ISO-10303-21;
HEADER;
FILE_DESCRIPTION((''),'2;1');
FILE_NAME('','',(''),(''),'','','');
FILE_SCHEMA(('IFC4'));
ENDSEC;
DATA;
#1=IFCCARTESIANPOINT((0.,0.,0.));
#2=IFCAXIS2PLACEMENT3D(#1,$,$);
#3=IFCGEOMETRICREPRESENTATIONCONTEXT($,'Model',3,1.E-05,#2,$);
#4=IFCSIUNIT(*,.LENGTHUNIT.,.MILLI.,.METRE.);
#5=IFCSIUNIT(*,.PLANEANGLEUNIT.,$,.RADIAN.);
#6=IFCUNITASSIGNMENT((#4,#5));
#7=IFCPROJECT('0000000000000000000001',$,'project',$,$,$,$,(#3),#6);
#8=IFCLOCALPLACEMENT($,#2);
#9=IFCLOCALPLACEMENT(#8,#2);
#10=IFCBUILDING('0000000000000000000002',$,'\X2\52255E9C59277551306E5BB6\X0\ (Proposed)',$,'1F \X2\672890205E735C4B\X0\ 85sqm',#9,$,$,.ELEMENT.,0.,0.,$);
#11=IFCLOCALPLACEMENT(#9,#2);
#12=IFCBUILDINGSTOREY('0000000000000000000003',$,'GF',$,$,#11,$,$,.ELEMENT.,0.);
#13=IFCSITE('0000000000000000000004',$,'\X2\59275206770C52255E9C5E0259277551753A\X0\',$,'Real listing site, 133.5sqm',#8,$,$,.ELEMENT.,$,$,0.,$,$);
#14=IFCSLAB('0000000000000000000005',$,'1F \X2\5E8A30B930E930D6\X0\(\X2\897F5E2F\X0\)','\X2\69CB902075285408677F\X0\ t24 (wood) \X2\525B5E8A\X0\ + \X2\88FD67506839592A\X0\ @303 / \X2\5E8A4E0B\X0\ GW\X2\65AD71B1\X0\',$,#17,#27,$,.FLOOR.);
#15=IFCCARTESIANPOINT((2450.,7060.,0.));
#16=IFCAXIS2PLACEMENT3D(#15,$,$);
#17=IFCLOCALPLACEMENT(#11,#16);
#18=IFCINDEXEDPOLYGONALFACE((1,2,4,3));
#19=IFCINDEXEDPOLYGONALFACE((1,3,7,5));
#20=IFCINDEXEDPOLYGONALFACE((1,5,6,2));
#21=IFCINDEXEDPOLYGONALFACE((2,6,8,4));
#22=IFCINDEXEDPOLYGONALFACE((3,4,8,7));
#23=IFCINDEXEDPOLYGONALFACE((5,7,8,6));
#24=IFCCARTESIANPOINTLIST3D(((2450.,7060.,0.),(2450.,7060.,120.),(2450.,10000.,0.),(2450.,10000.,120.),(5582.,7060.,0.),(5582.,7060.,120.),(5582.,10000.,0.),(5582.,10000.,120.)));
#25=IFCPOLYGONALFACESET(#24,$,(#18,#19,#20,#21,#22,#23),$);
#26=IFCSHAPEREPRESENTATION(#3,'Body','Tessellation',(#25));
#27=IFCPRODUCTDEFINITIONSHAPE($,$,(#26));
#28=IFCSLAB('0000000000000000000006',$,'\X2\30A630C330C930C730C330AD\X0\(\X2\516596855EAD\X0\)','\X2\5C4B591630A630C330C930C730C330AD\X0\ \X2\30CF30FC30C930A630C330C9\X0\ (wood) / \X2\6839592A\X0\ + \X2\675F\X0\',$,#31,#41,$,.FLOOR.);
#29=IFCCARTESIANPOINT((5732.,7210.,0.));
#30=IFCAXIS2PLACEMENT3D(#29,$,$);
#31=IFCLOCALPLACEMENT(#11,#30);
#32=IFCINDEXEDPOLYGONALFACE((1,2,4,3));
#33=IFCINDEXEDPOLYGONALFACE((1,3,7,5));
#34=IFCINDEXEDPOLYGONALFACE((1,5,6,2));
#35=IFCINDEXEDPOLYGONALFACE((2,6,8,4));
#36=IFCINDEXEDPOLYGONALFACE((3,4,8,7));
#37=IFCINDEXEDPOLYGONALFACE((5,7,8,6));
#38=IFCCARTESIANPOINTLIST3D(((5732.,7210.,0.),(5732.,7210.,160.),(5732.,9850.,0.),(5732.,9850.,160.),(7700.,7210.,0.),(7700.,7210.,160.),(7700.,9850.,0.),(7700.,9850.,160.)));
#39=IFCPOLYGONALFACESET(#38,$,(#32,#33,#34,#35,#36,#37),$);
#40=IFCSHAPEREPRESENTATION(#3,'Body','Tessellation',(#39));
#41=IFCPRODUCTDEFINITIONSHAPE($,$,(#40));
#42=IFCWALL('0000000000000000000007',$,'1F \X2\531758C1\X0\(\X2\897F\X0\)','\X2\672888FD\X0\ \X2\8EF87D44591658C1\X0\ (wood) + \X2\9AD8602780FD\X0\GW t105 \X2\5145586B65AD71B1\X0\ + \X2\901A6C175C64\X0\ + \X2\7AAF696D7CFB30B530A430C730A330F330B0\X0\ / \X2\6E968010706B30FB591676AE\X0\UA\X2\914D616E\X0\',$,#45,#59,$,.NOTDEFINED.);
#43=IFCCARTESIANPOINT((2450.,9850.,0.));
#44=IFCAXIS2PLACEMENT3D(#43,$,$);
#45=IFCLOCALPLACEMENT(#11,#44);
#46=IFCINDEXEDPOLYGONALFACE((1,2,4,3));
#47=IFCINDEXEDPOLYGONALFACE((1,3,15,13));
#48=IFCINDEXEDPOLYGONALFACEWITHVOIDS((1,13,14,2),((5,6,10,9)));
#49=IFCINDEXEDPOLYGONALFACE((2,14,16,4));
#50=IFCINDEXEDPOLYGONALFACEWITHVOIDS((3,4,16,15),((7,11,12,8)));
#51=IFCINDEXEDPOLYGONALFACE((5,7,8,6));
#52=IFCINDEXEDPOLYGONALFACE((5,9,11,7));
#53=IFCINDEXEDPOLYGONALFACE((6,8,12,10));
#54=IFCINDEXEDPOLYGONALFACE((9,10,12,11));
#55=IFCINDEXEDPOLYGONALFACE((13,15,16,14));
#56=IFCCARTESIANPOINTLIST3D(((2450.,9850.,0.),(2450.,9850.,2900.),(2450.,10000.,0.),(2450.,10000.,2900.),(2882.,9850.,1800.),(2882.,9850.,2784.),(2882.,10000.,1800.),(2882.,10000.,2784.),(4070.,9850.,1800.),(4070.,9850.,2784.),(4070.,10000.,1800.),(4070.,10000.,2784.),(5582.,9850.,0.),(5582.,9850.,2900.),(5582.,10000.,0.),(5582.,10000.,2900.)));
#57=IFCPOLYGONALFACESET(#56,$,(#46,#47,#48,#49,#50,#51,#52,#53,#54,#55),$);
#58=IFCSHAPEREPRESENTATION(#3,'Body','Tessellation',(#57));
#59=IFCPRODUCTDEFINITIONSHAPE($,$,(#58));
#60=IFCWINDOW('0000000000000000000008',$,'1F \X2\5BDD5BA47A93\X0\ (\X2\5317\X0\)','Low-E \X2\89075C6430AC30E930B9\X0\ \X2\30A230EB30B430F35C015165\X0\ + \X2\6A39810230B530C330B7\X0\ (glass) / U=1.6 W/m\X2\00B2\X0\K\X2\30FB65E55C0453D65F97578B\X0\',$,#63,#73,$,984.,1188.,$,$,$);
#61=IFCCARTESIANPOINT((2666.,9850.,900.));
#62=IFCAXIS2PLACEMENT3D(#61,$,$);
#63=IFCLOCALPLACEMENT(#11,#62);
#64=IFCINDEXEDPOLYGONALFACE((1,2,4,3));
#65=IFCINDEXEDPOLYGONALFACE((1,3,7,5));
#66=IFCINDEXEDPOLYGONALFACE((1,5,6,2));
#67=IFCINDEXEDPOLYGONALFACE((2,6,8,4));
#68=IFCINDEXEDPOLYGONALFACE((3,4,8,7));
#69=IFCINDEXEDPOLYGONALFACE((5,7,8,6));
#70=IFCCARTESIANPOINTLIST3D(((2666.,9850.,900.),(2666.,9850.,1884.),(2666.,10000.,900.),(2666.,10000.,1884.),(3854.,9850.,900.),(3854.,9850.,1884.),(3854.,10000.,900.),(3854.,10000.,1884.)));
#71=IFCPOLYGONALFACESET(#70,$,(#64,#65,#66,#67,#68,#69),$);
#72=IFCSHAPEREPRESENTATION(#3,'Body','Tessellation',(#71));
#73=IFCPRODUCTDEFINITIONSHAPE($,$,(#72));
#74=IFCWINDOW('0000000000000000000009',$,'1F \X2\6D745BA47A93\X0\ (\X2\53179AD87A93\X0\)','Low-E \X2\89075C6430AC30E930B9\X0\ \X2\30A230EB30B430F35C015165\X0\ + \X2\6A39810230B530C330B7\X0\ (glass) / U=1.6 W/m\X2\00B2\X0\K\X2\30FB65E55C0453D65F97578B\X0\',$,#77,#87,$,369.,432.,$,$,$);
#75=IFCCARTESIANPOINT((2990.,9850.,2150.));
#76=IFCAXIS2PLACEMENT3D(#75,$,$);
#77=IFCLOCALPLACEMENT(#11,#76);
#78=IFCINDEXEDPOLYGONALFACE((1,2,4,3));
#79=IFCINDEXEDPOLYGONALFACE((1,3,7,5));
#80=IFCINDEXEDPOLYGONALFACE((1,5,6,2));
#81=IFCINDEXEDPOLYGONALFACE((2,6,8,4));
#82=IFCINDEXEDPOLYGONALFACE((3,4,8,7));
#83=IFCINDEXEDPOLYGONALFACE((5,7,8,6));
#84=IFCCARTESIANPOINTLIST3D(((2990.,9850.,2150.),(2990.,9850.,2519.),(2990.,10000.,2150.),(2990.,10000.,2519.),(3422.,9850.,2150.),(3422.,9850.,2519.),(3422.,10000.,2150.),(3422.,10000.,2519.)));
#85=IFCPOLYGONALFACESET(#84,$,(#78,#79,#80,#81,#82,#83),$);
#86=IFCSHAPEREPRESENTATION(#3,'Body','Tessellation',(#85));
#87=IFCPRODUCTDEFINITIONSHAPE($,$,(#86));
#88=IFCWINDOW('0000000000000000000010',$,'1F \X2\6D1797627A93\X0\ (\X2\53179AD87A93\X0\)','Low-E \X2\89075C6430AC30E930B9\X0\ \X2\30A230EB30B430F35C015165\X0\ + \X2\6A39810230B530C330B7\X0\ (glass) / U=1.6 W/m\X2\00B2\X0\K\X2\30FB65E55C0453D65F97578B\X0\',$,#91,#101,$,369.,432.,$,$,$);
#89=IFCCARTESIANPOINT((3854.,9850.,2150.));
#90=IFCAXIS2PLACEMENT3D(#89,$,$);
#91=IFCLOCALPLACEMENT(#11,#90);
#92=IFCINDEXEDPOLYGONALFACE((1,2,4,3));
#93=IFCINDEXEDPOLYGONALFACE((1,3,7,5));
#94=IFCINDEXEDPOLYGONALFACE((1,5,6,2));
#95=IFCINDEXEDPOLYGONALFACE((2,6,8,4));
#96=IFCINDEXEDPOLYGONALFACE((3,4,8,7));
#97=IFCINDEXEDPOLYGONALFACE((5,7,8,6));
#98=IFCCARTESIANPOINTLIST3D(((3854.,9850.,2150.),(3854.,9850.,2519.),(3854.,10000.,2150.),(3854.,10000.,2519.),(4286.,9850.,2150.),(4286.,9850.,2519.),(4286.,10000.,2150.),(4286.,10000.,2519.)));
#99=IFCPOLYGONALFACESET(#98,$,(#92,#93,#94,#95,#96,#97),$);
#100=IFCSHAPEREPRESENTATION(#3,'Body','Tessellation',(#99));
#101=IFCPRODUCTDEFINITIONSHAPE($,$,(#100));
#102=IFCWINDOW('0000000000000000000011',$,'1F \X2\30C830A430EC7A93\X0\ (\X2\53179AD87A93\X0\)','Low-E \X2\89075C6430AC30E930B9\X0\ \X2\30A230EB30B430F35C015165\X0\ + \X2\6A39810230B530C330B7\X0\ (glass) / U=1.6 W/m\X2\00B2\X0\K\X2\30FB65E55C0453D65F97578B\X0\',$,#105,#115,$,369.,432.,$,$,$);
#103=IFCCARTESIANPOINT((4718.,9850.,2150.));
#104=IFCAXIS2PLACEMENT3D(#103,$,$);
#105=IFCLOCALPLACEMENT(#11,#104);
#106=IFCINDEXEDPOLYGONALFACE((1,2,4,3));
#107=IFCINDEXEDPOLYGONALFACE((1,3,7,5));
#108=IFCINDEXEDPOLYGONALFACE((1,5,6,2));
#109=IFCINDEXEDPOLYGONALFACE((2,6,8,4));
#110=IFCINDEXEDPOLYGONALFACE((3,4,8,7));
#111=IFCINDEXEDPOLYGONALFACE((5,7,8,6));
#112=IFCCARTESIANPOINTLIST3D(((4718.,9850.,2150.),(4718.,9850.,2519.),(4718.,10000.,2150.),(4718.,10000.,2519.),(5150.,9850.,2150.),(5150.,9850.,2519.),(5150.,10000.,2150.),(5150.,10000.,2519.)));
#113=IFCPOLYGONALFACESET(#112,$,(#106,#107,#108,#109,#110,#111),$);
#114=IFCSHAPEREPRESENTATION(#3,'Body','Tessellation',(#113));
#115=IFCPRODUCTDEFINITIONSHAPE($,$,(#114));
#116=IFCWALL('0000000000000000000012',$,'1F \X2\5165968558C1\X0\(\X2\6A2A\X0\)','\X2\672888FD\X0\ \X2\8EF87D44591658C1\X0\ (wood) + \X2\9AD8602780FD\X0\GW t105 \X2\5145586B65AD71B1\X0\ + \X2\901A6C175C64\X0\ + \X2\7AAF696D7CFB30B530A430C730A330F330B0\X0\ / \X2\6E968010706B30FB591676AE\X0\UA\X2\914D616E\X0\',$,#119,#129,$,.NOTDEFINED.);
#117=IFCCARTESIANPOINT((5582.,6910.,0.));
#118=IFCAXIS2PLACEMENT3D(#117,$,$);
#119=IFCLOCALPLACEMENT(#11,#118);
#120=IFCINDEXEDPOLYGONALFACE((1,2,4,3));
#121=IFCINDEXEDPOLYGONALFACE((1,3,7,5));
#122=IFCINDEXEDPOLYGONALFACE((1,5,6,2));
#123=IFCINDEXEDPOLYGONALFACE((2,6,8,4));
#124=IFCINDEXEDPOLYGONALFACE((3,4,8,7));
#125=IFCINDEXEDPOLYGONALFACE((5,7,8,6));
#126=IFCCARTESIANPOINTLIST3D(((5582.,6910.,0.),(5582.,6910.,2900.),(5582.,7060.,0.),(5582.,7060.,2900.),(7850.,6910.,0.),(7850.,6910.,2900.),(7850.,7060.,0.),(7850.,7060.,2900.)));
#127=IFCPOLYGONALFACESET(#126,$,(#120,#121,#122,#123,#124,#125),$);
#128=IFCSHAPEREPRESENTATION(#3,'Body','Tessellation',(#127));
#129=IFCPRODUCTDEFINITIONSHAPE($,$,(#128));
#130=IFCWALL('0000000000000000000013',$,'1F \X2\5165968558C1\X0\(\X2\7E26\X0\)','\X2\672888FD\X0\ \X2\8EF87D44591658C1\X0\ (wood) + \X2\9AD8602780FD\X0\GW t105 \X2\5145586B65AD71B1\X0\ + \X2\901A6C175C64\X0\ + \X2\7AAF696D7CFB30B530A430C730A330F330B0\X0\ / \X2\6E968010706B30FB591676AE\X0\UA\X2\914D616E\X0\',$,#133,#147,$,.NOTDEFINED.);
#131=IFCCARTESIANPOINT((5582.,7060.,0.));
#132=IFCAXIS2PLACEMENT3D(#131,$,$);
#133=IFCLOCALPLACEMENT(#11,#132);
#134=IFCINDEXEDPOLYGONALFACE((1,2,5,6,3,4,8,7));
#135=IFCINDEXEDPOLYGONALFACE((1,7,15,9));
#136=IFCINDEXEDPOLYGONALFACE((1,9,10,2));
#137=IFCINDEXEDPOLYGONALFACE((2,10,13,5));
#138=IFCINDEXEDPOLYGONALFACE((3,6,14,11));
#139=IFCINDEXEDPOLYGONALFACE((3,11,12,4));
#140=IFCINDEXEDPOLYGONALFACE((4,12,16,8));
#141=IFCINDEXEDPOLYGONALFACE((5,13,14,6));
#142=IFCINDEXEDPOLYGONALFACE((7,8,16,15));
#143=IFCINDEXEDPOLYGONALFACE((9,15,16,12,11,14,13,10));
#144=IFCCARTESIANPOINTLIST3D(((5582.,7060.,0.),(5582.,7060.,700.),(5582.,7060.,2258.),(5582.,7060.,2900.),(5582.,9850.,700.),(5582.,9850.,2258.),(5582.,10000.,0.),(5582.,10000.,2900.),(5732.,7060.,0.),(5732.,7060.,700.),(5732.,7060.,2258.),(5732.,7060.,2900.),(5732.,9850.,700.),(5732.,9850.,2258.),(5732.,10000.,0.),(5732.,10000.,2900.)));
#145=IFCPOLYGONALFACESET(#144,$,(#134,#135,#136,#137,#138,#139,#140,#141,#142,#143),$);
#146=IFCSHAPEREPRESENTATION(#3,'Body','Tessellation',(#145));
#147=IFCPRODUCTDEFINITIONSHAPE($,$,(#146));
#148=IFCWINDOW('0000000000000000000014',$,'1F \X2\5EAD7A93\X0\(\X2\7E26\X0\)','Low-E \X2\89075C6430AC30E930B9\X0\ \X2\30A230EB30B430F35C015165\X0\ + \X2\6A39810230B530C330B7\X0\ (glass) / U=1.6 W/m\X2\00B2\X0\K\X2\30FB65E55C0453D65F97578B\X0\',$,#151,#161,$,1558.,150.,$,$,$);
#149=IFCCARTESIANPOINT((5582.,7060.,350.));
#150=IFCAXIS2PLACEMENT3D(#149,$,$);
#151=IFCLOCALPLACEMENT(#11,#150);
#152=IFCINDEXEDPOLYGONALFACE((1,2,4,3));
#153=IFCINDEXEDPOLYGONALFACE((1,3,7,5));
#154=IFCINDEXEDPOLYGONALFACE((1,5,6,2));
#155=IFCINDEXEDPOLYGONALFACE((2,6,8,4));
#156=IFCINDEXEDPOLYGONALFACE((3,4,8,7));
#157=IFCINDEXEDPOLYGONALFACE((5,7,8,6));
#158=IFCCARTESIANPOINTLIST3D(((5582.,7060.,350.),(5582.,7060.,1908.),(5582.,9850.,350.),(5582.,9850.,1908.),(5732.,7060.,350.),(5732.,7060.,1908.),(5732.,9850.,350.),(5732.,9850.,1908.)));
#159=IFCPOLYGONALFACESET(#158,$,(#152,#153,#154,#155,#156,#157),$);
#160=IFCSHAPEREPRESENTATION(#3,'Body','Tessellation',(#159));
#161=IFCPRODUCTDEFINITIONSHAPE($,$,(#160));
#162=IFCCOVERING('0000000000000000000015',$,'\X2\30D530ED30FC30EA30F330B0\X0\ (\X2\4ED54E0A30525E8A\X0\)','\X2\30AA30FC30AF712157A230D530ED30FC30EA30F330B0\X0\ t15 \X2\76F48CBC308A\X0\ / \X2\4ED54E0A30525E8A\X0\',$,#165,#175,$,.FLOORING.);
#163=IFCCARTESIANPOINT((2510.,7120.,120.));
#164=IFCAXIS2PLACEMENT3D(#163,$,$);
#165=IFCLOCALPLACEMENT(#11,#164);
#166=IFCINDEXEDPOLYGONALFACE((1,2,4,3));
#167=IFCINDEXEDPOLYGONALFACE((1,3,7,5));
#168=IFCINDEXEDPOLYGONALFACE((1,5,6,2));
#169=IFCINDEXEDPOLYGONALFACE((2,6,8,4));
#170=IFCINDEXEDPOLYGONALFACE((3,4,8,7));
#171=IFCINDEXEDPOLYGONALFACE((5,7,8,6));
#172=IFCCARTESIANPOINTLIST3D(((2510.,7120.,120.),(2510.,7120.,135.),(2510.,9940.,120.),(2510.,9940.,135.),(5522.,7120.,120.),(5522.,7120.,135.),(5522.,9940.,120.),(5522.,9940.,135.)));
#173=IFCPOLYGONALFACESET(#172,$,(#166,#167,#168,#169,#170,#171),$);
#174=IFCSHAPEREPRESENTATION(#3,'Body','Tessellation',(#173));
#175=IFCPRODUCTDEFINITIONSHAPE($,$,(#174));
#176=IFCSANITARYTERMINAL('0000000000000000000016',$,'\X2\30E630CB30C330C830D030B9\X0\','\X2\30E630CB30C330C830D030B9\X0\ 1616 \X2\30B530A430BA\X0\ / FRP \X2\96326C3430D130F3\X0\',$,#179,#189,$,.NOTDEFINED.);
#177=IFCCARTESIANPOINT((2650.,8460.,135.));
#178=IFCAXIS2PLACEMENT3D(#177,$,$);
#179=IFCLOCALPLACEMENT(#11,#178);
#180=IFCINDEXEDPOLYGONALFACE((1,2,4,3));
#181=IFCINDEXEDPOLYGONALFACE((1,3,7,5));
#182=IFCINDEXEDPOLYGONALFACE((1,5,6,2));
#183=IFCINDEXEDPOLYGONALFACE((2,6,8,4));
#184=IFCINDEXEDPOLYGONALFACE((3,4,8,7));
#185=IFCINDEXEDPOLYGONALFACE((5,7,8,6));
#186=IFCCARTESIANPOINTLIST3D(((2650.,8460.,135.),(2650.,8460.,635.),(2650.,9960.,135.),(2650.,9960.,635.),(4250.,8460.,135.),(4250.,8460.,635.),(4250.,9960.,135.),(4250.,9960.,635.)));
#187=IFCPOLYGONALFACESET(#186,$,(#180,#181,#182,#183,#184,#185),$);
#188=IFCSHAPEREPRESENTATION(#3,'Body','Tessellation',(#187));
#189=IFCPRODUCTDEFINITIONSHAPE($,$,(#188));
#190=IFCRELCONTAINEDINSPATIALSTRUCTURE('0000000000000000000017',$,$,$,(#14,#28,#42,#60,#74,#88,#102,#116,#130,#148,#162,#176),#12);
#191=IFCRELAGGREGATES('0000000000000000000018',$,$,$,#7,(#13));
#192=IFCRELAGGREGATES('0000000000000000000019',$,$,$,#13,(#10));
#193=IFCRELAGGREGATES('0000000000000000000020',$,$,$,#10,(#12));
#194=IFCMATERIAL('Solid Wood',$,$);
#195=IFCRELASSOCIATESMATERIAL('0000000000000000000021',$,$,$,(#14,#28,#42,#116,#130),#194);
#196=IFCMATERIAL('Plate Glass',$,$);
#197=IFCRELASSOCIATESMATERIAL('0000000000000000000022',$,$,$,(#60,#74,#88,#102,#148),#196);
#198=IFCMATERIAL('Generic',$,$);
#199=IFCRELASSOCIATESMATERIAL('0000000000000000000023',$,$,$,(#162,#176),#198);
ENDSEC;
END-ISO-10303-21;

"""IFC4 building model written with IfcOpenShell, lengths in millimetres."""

from ifc_helpers import new_model, si_unit, frame, frame_2d, origin, place, context, project, spatial, rectangle, extrude, material, element, fill, save


model = new_model("IFC4")

# Units and contexts
model_context = context("Model", 3, precision=1e-05, world=origin())
ifc_project = project(units=[si_unit("LENGTHUNIT", "METRE", prefix="MILLI"), si_unit("PLANEANGLEUNIT", "RADIAN")], contexts=[model_context])

# Site, building, storey
site_placement = place(None, origin())
site = spatial("IfcSite", under=ifc_project, at=site_placement, Name="大分県別府市大畑町", ObjectType="Real listing site, 133.5sqm", CompositionType="ELEMENT", RefElevation=0.0)
building_placement = place(site_placement, origin())
building = spatial("IfcBuilding", under=site, at=building_placement, Name="別府大畑の家 (Proposed)", ObjectType="1F 木造平屋 85sqm", CompositionType="ELEMENT", ElevationOfRefHeight=0.0, ElevationOfTerrain=0.0)
storey_placement = place(building_placement, origin())
storey = spatial("IfcBuildingStorey", under=building, at=storey_placement, Name="GF", CompositionType="ELEMENT", Elevation=0.0)

# Slabs
ifc_material_1 = material(Name="Solid Wood")
slab_1_placement = place(storey_placement, frame((2450.0, 7060.0, 0.0)))
element("IfcSlab", 1, at=slab_1_placement, inside=storey, material=ifc_material_1, Name="1F 床スラブ(西帯)", Description="構造用合板 t24 (wood) 剛床 + 製材根太 @303 / 床下 GW断熱", PredefinedType="FLOOR", context=model_context, shape_type="SweptSolid", body=[
    extrude(rectangle(XDim=3132.0, YDim=2940.0, at=frame_2d((1566.0, 1470.0))), frame((2450.0, 7060.0, 0.0)), (0.0, 0.0, 1.0), 120.0),
])
slab_2_placement = place(storey_placement, frame((5732.0, 7210.0, 0.0)))
element("IfcSlab", 2, at=slab_2_placement, inside=storey, material=ifc_material_1, Name="ウッドデッキ(入隅庭)", Description="屋外ウッドデッキ ハードウッド (wood) / 根太 + 束", PredefinedType="FLOOR", context=model_context, shape_type="SweptSolid", body=[
    extrude(rectangle(XDim=1968.0, YDim=2640.0, at=frame_2d((984.0, 1320.0))), frame((5732.0, 7210.0, 0.0)), (0.0, 0.0, 1.0), 160.0),
])

# Wall, openings, windows
wall_1_placement = place(storey_placement, frame((2450.0, 9850.0, 0.0)))
wall_1 = element("IfcWall", 3, at=wall_1_placement, inside=storey, material=ifc_material_1, Name="1F 北壁(西)", Description="木製 軸組外壁 (wood) + 高性能GW t105 充填断熱 + 通気層 + 窯業系サイディング / 準耐火・外皮UA配慮", PredefinedType="NOTDEFINED", context=model_context, shape_type="SweptSolid", body=[
    extrude(rectangle(XDim=3132.0, YDim=150.0, at=frame_2d((1566.0, 75.0))), frame((2450.0, 9850.0, 0.0)), (0.0, 0.0, 1.0), 2900.0),
])
opening_1_placement = place(storey_placement, frame((2666.0, 9850.0, 900.0)))
opening_1 = element("IfcOpeningElement", 4, at=opening_1_placement, cuts=wall_1, PredefinedType="NOTDEFINED", context=model_context, shape_type="SweptSolid", body=[
    extrude(rectangle(XDim=1188.0, YDim=150.0, at=frame_2d((594.0, 75.0))), frame((2666.0, 9850.0, 900.0)), (0.0, 0.0, 1.0), 984.0),
])
opening_2_placement = place(storey_placement, frame((2990.0, 9850.0, 2150.0)))
opening_2 = element("IfcOpeningElement", 5, at=opening_2_placement, cuts=wall_1, PredefinedType="NOTDEFINED", context=model_context, shape_type="SweptSolid", body=[
    extrude(rectangle(XDim=432.0, YDim=150.0, at=frame_2d((216.0, 75.0))), frame((2990.0, 9850.0, 2150.0)), (0.0, 0.0, 1.0), 369.0),
])
opening_3_placement = place(storey_placement, frame((3854.0, 9850.0, 2150.0)))
opening_3 = element("IfcOpeningElement", 6, at=opening_3_placement, cuts=wall_1, PredefinedType="NOTDEFINED", context=model_context, shape_type="SweptSolid", body=[
    extrude(rectangle(XDim=432.0, YDim=150.0, at=frame_2d((216.0, 75.0))), frame((3854.0, 9850.0, 2150.0)), (0.0, 0.0, 1.0), 369.0),
])
opening_4_placement = place(storey_placement, frame((4718.0, 9850.0, 2150.0)))
opening_4 = element("IfcOpeningElement", 7, at=opening_4_placement, cuts=wall_1, PredefinedType="NOTDEFINED", context=model_context, shape_type="SweptSolid", body=[
    extrude(rectangle(XDim=432.0, YDim=150.0, at=frame_2d((216.0, 75.0))), frame((4718.0, 9850.0, 2150.0)), (0.0, 0.0, 1.0), 369.0),
])
ifc_material_2 = material(Name="Plate Glass")
window_1_placement = place(storey_placement, frame((2666.0, 9850.0, 900.0)))
window_1 = element("IfcWindow", 8, at=window_1_placement, inside=storey, material=ifc_material_2, Name="1F 寝室窓 (北)", Description="Low-E 複層ガラス アルゴン封入 + 樹脂サッシ (glass) / U=1.6 W/m²K・日射取得型", OverallHeight=984.0, OverallWidth=1188.0, context=model_context, shape_type="SweptSolid", body=[
    extrude(rectangle(XDim=1188.0, YDim=150.0, at=frame_2d((594.0, 75.0))), frame((2666.0, 9850.0, 900.0)), (0.0, 0.0, 1.0), 984.0),
])
fill(opening_1, window_1)
window_2_placement = place(storey_placement, frame((2990.0, 9850.0, 2150.0)))
window_2 = element("IfcWindow", 9, at=window_2_placement, inside=storey, material=ifc_material_2, Name="1F 浴室窓 (北高窓)", Description="Low-E 複層ガラス アルゴン封入 + 樹脂サッシ (glass) / U=1.6 W/m²K・日射取得型", OverallHeight=369.0, OverallWidth=432.0, context=model_context, shape_type="SweptSolid", body=[
    extrude(rectangle(XDim=432.0, YDim=150.0, at=frame_2d((216.0, 75.0))), frame((2990.0, 9850.0, 2150.0)), (0.0, 0.0, 1.0), 369.0),
])
fill(opening_2, window_2)
window_3_placement = place(storey_placement, frame((3854.0, 9850.0, 2150.0)))
window_3 = element("IfcWindow", 10, at=window_3_placement, inside=storey, material=ifc_material_2, Name="1F 洗面窓 (北高窓)", Description="Low-E 複層ガラス アルゴン封入 + 樹脂サッシ (glass) / U=1.6 W/m²K・日射取得型", OverallHeight=369.0, OverallWidth=432.0, context=model_context, shape_type="SweptSolid", body=[
    extrude(rectangle(XDim=432.0, YDim=150.0, at=frame_2d((216.0, 75.0))), frame((3854.0, 9850.0, 2150.0)), (0.0, 0.0, 1.0), 369.0),
])
fill(opening_3, window_3)
window_4_placement = place(storey_placement, frame((4718.0, 9850.0, 2150.0)))
window_4 = element("IfcWindow", 11, at=window_4_placement, inside=storey, material=ifc_material_2, Name="1F トイレ窓 (北高窓)", Description="Low-E 複層ガラス アルゴン封入 + 樹脂サッシ (glass) / U=1.6 W/m²K・日射取得型", OverallHeight=369.0, OverallWidth=432.0, context=model_context, shape_type="SweptSolid", body=[
    extrude(rectangle(XDim=432.0, YDim=150.0, at=frame_2d((216.0, 75.0))), frame((4718.0, 9850.0, 2150.0)), (0.0, 0.0, 1.0), 369.0),
])
fill(opening_4, window_4)

# Wall
wall_2_placement = place(storey_placement, frame((5582.0, 6910.0, 0.0)))
element("IfcWall", 12, at=wall_2_placement, inside=storey, material=ifc_material_1, Name="1F 入隅壁(横)", Description="木製 軸組外壁 (wood) + 高性能GW t105 充填断熱 + 通気層 + 窯業系サイディング / 準耐火・外皮UA配慮", PredefinedType="NOTDEFINED", context=model_context, shape_type="SweptSolid", body=[
    extrude(rectangle(XDim=2268.0, YDim=150.0, at=frame_2d((1134.0, 75.0))), frame((5582.0, 6910.0, 0.0)), (0.0, 0.0, 1.0), 2900.0),
])

# Wall, opening, window
wall_3_placement = place(storey_placement, frame((5582.0, 7060.0, 0.0)))
wall_3 = element("IfcWall", 13, at=wall_3_placement, inside=storey, material=ifc_material_1, Name="1F 入隅壁(縦)", Description="木製 軸組外壁 (wood) + 高性能GW t105 充填断熱 + 通気層 + 窯業系サイディング / 準耐火・外皮UA配慮", PredefinedType="NOTDEFINED", context=model_context, shape_type="SweptSolid", body=[
    extrude(rectangle(XDim=150.0, YDim=2940.0, at=frame_2d((75.0, 1470.0))), frame((5582.0, 7060.0, 0.0)), (0.0, 0.0, 1.0), 2900.0),
])
opening_5_placement = place(storey_placement, frame((5582.0, 7060.0, 350.0)))
opening_5 = element("IfcOpeningElement", 14, at=opening_5_placement, cuts=wall_3, PredefinedType="NOTDEFINED", context=model_context, shape_type="SweptSolid", body=[
    extrude(rectangle(XDim=150.0, YDim=2790.0, at=frame_2d((75.0, 1395.0))), frame((5582.0, 7060.0, 350.0)), (0.0, 0.0, 1.0), 1558.0),
])
window_5_placement = place(storey_placement, frame((5582.0, 7060.0, 350.0)))
window_5 = element("IfcWindow", 15, at=window_5_placement, inside=storey, material=ifc_material_2, Name="1F 庭窓(縦)", Description="Low-E 複層ガラス アルゴン封入 + 樹脂サッシ (glass) / U=1.6 W/m²K・日射取得型", OverallHeight=1558.0, OverallWidth=150.0, context=model_context, shape_type="SweptSolid", body=[
    extrude(rectangle(XDim=150.0, YDim=2790.0, at=frame_2d((75.0, 1395.0))), frame((5582.0, 7060.0, 350.0)), (0.0, 0.0, 1.0), 1558.0),
])
fill(opening_5, window_5)

# Covering
ifc_material_3 = material(Name="Generic")
covering_placement = place(storey_placement, frame((2510.0, 7120.0, 120.0)))
element("IfcCovering", 16, at=covering_placement, inside=storey, material=ifc_material_3, Name="フローリング (仕上げ床)", Description="オーク無垢フローリング t15 直貼り / 仕上げ床", PredefinedType="FLOORING", context=model_context, shape_type="SweptSolid", body=[
    extrude(rectangle(XDim=3012.0, YDim=2820.0, at=frame_2d((1506.0, 1410.0))), frame((2510.0, 7120.0, 120.0)), (0.0, 0.0, 1.0), 15.0),
])

# Sanitary terminal
sanitary_terminal_1_placement = place(storey_placement, frame((2650.0, 8460.0, 135.0)))
element("IfcSanitaryTerminal", 17, at=sanitary_terminal_1_placement, inside=storey, material=ifc_material_3, Name="ユニットバス", Description="ユニットバス 1616 サイズ / FRP 防水パン", PredefinedType="NOTDEFINED", context=model_context, shape_type="SweptSolid", body=[
    extrude(rectangle(XDim=1600.0, YDim=1500.0, at=frame_2d((800.0, 750.0))), frame((2650.0, 8460.0, 135.0)), (0.0, 0.0, 1.0), 500.0),
])

save(model, "model.ifc")
